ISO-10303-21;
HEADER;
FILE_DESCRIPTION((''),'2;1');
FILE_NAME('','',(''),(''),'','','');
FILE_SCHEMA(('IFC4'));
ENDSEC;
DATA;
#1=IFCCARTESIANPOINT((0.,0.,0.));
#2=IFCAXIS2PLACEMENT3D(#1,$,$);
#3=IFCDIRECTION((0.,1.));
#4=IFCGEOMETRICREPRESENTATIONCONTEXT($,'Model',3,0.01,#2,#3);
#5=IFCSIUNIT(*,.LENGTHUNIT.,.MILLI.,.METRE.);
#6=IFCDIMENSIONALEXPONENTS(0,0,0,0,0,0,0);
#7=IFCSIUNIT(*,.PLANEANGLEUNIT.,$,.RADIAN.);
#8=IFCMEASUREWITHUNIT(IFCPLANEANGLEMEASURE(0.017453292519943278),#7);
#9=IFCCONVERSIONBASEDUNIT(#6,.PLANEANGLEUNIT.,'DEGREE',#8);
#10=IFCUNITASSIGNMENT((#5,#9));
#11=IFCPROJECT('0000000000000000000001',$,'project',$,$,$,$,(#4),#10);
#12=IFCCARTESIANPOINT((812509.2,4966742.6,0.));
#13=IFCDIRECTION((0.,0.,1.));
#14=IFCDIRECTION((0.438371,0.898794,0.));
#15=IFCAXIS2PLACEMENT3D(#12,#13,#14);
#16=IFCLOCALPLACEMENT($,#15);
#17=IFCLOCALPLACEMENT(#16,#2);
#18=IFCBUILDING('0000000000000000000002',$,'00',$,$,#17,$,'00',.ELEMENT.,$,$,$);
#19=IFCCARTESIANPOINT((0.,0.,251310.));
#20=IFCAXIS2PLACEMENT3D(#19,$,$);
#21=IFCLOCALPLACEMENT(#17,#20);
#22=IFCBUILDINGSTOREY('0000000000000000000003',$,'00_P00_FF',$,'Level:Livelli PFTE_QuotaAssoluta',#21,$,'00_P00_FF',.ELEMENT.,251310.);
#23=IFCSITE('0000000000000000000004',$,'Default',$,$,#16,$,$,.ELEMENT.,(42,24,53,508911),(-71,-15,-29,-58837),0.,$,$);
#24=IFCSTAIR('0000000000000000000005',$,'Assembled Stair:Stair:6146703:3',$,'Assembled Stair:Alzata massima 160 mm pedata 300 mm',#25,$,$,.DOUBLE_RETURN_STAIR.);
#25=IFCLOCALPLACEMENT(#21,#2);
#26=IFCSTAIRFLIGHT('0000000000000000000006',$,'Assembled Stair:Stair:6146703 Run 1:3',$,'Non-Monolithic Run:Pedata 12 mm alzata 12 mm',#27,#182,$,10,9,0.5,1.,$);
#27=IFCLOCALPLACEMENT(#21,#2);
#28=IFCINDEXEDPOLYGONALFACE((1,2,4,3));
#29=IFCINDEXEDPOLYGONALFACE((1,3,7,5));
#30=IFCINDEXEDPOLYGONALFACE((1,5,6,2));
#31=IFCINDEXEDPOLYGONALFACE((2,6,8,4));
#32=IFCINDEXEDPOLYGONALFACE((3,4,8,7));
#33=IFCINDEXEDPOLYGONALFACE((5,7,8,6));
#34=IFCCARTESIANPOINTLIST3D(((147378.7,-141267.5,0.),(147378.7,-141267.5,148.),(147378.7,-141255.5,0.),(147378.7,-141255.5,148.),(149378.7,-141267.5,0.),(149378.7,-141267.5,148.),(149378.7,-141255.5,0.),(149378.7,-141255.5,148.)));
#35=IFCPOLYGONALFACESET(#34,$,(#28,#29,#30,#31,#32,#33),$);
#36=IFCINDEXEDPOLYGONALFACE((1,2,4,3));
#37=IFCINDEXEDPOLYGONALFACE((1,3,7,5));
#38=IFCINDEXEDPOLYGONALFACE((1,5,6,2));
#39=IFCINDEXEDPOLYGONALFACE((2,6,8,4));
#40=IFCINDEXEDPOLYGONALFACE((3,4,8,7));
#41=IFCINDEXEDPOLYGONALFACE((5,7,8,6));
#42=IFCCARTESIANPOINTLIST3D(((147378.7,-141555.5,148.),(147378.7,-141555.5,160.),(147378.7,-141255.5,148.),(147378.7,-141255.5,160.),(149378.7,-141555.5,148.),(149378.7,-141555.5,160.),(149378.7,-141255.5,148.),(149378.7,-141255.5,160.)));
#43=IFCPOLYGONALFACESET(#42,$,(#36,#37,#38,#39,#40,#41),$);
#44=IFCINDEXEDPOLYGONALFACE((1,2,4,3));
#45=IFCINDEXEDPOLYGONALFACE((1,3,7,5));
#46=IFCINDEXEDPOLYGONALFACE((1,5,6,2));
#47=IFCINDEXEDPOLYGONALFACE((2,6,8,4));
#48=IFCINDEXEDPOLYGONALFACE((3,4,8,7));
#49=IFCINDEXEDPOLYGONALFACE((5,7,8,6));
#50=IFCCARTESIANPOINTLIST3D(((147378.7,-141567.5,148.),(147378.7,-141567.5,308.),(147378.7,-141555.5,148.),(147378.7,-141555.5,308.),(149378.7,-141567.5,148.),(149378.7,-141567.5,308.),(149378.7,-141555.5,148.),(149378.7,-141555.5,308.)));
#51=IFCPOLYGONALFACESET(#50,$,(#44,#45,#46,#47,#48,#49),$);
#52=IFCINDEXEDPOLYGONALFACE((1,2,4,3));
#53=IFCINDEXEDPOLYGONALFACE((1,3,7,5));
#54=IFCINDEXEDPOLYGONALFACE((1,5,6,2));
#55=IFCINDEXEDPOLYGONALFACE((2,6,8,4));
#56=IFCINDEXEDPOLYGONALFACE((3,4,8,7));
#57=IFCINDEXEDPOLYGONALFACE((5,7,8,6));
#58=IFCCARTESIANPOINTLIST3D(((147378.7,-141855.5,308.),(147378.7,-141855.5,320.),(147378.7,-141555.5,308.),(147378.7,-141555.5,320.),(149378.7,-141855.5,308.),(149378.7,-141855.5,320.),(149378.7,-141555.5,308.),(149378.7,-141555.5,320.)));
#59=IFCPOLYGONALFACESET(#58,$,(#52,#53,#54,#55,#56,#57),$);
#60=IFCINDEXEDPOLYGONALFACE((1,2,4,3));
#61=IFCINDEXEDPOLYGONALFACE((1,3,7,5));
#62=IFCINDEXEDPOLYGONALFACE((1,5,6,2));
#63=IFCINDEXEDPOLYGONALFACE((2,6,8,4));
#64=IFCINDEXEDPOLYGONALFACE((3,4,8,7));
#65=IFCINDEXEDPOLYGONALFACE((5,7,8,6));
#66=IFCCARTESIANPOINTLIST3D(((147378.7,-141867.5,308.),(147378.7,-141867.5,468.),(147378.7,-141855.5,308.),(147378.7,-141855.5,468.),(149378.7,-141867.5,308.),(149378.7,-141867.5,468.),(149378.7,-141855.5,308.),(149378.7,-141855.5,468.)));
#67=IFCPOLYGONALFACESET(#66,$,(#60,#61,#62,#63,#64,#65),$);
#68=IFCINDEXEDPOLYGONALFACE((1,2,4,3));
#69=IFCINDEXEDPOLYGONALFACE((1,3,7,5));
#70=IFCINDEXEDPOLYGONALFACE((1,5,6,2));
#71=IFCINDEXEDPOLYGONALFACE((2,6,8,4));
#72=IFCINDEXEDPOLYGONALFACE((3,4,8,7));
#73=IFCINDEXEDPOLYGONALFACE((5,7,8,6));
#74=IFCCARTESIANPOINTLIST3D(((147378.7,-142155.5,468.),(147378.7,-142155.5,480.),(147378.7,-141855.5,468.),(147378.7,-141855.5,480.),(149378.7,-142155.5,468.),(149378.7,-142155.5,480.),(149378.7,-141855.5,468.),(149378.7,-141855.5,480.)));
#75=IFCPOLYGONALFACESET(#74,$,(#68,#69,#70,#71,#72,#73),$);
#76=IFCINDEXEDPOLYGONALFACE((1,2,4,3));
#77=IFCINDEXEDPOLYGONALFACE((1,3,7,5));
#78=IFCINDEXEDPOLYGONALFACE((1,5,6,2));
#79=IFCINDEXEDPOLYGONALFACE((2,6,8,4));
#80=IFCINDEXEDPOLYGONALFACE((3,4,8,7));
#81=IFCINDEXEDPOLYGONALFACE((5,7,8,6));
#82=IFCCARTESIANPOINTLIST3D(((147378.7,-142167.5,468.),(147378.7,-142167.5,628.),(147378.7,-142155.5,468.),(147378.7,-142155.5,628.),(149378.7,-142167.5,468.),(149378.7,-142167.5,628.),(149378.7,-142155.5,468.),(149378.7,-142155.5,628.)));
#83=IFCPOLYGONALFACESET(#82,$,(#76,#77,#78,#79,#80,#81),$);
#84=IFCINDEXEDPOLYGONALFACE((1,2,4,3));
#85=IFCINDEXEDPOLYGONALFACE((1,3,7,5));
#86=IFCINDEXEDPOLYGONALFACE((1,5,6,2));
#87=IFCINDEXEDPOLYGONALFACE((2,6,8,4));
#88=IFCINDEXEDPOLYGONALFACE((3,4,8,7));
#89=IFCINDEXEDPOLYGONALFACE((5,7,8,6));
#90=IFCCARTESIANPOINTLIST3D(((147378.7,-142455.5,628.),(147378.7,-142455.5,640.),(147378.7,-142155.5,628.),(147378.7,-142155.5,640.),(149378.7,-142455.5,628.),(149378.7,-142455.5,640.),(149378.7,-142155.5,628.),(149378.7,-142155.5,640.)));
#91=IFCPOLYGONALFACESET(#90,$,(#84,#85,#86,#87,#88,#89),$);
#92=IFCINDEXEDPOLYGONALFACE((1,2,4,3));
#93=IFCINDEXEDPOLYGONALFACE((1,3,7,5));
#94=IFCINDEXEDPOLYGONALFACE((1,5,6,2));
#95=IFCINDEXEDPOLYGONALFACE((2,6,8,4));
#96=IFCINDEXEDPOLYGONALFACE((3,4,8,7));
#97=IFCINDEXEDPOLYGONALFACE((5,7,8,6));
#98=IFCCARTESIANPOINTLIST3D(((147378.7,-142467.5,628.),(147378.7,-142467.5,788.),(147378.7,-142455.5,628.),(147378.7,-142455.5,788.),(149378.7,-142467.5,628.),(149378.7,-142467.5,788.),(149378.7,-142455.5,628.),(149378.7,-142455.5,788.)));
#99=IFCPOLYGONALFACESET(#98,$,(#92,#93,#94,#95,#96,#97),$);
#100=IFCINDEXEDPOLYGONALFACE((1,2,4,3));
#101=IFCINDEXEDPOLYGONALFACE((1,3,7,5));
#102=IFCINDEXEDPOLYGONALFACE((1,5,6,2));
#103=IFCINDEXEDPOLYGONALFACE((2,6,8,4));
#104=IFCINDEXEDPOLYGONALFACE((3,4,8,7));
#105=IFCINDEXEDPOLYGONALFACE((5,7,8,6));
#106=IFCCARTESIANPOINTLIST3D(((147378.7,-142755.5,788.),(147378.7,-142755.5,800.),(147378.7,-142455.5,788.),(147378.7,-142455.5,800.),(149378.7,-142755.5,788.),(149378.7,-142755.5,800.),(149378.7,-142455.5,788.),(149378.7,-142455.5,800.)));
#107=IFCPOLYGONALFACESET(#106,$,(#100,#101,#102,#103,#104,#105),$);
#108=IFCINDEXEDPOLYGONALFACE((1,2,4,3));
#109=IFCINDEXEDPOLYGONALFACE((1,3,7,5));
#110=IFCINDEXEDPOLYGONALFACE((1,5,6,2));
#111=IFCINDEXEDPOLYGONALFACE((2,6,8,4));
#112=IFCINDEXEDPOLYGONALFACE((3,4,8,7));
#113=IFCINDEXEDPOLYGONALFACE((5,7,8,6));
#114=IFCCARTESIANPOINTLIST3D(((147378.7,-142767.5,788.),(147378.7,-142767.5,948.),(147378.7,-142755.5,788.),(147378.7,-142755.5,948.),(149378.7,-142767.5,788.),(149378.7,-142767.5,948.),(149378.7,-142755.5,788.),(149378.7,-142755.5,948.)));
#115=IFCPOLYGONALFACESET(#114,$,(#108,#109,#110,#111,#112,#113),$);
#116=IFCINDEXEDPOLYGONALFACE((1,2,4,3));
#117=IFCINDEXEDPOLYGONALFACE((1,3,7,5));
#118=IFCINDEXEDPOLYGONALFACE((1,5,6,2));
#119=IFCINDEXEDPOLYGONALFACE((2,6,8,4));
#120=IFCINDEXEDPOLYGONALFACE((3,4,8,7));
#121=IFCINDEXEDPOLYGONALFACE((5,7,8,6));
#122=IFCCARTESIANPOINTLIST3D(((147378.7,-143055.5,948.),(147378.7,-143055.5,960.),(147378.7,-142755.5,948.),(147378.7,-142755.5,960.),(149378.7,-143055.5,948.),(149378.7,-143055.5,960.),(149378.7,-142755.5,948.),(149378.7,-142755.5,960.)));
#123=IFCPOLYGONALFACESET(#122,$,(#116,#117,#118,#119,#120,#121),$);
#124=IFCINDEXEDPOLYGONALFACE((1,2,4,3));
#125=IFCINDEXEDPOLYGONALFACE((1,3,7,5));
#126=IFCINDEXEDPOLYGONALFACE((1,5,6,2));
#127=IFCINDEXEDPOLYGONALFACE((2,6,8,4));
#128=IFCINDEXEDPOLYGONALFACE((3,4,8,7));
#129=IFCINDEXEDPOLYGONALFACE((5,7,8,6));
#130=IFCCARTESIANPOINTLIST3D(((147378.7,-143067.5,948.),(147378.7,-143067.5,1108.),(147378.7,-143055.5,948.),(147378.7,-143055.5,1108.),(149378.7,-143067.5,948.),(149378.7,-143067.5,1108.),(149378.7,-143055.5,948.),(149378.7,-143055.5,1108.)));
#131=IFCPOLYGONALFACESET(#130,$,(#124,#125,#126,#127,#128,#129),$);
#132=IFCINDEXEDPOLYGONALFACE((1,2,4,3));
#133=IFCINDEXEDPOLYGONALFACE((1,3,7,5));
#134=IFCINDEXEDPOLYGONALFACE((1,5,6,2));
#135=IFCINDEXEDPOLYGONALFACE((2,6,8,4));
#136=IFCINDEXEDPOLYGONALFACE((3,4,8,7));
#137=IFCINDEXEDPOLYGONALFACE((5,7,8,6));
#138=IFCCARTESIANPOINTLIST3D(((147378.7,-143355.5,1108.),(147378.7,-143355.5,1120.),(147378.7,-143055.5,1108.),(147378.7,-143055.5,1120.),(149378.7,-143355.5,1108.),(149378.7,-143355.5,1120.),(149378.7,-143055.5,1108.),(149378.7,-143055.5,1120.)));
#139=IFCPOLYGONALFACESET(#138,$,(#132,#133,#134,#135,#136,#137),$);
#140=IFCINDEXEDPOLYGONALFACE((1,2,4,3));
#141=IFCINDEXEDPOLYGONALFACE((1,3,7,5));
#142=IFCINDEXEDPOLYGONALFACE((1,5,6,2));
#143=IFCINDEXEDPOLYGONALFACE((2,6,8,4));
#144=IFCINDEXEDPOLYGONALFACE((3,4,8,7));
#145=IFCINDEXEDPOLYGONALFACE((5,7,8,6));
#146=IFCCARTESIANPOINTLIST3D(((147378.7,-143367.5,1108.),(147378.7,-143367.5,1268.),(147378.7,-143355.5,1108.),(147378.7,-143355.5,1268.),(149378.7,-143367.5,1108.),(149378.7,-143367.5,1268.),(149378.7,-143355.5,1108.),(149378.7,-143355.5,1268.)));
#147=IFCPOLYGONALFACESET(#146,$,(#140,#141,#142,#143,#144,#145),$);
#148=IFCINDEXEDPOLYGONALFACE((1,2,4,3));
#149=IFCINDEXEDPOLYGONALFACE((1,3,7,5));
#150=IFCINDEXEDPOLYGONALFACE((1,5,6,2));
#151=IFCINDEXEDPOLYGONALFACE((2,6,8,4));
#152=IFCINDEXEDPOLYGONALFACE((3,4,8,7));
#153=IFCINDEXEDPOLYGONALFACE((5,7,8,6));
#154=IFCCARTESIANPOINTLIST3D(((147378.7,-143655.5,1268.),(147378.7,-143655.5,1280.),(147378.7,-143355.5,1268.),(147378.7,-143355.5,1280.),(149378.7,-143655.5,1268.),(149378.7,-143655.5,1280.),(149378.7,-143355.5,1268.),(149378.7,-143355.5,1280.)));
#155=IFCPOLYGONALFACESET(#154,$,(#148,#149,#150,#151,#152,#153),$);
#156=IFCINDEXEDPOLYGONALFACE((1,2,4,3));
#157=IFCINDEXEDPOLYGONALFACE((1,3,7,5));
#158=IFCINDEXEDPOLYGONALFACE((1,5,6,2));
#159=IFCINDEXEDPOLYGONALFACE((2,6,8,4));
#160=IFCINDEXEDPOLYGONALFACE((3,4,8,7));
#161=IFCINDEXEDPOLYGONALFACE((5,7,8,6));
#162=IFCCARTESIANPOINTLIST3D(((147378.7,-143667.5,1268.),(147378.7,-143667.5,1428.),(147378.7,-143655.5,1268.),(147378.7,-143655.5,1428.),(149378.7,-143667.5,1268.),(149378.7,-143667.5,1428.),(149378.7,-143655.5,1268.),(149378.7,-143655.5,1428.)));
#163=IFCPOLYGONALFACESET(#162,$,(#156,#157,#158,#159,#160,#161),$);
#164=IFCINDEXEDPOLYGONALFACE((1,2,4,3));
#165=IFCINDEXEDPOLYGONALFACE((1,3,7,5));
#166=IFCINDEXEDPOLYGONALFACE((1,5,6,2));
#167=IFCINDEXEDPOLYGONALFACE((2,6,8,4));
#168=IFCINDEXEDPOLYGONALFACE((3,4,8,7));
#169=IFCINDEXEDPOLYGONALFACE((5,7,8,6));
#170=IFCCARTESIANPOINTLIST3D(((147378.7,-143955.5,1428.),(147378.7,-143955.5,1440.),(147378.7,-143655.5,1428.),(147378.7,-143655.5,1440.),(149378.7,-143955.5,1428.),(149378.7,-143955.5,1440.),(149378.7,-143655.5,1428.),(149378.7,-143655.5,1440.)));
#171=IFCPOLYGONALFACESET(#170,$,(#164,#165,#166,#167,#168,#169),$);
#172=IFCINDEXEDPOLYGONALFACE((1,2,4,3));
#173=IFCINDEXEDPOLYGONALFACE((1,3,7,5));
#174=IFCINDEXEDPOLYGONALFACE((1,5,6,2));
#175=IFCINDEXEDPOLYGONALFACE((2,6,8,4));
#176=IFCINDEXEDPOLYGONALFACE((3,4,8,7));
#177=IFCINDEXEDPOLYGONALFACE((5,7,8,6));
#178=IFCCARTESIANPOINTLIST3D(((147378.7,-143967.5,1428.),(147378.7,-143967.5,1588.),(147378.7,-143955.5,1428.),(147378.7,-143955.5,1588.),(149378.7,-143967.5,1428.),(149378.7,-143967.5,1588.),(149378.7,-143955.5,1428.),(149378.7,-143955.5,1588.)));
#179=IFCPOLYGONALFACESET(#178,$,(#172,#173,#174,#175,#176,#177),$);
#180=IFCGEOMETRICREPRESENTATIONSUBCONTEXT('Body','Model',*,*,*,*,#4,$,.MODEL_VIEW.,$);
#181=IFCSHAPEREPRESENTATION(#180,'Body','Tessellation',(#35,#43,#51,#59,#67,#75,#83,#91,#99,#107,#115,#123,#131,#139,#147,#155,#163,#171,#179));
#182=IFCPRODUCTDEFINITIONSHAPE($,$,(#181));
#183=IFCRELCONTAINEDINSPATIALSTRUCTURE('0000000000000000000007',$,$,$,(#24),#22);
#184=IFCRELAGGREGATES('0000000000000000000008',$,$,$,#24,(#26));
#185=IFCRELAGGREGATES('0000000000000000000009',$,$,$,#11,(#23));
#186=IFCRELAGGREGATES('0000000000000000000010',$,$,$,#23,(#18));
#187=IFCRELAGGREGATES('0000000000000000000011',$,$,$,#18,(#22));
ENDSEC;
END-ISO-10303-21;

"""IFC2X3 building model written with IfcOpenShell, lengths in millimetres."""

from ifc_helpers import new_model, entity, si_unit, converted_unit, direction, frame, frame_2d, origin, origin_2d_with_axis, place, context, subcontext, project, spatial, rectangle, extrude, element, aggregate, save


model = new_model("IFC2X3")

# Units and contexts
model_context = context("Model", 3, precision=0.01, world=origin(), true_north=direction((0.0, 1.0)))
body_context = subcontext(model_context, "Body", "Model", "MODEL_VIEW")
ifc_project = project(units=[si_unit("LENGTHUNIT", "METRE", prefix="MILLI"), converted_unit("PLANEANGLEUNIT", "DEGREE", entity("IfcPlaneAngleMeasure", 0.017453292519943278), si_unit("PLANEANGLEUNIT", "RADIAN"), dimensions=[0, 0, 0, 0, 0, 0, 0])], contexts=[model_context])

# Site, building, storey
site_placement = place(None, frame((812509.2, 4966742.6, 0.0), z_axis=(0.0, 0.0, 1.0), x_axis=(0.438371, 0.898794, 0.0)))
site = spatial("IfcSite", under=ifc_project, at=site_placement, Name="Default", CompositionType="ELEMENT", RefLatitude=(42, 24, 53, 508911), RefLongitude=(-71, -15, -29, -58837), RefElevation=0.0)
building_placement = place(site_placement, origin())
building = spatial("IfcBuilding", under=site, at=building_placement, Name="00", LongName="00", CompositionType="ELEMENT")
storey_placement = place(building_placement, frame((0.0, 0.0, 251310.0)))
storey = spatial("IfcBuildingStorey", under=building, at=storey_placement, Name="00_P00_FF", ObjectType="Level:Livelli PFTE_QuotaAssoluta", LongName="00_P00_FF", CompositionType="ELEMENT", Elevation=251310.0)

# Stair, stair flight
stair_1_placement = place(storey_placement, origin())
stair_1 = element("IfcStair", 1, at=stair_1_placement, inside=storey, Name="Assembled Stair:Stair:6146703:3", ObjectType="Assembled Stair:Alzata massima 160 mm pedata 300 mm", ShapeType="DOUBLE_RETURN_STAIR")
stair_flight_1_placement = place(stair_1_placement, origin())
stair_flight_1 = element("IfcStairFlight", 2, at=stair_flight_1_placement, Name="Assembled Stair:Stair:6146703 Run 1:3", ObjectType="Non-Monolithic Run:Pedata 12 mm alzata 12 mm", NumberOfRiser=10, NumberOfTreads=9, RiserHeight=0.5, TreadLength=1.0, context=body_context, shape_type="SweptSolid", body=[
    extrude(rectangle(XDim=2000.0, YDim=12.0, at=origin_2d_with_axis()), frame((148378.7, -141261.5, 0.0)), (0.0, 0.0, 1.0), 148.0),
    extrude(rectangle(XDim=300.0, YDim=2000.0, at=frame_2d((0.0, 0.0), x_axis=(1.0, 0.0))), frame((148378.7, -141405.5, 148.0), z_axis=(0.0, 0.0, 1.0), x_axis=(0.0, 1.0, 0.0)), (0.0, 0.0, 1.0), 12.0),
    extrude(rectangle(XDim=2000.0, YDim=12.0, at=origin_2d_with_axis()), frame((148378.7, -141561.5, 148.0)), (0.0, 0.0, 1.0), 160.0),
    extrude(rectangle(XDim=300.0, YDim=2000.0, at=origin_2d_with_axis()), frame((148378.7, -141705.5, 308.0), z_axis=(0.0, 0.0, 1.0), x_axis=(0.0, 1.0, 0.0)), (0.0, 0.0, 1.0), 12.0),
    extrude(rectangle(XDim=2000.0, YDim=12.0, at=origin_2d_with_axis()), frame((148378.7, -141861.5, 308.0)), (0.0, 0.0, 1.0), 160.0),
    extrude(rectangle(XDim=300.0, YDim=2000.0, at=origin_2d_with_axis()), frame((148378.7, -142005.5, 468.0), z_axis=(0.0, 0.0, 1.0), x_axis=(0.0, 1.0, 0.0)), (0.0, 0.0, 1.0), 12.0),
    extrude(rectangle(XDim=2000.0, YDim=12.0, at=origin_2d_with_axis()), frame((148378.7, -142161.5, 468.0)), (0.0, 0.0, 1.0), 160.0),
    extrude(rectangle(XDim=300.0, YDim=2000.0, at=origin_2d_with_axis()), frame((148378.7, -142305.5, 628.0), z_axis=(0.0, 0.0, 1.0), x_axis=(0.0, 1.0, 0.0)), (0.0, 0.0, 1.0), 12.0),
    extrude(rectangle(XDim=2000.0, YDim=12.0, at=origin_2d_with_axis()), frame((148378.7, -142461.5, 628.0)), (0.0, 0.0, 1.0), 160.0),
    extrude(rectangle(XDim=300.0, YDim=2000.0, at=origin_2d_with_axis()), frame((148378.7, -142605.5, 788.0), z_axis=(0.0, 0.0, 1.0), x_axis=(0.0, 1.0, 0.0)), (0.0, 0.0, 1.0), 12.0),
    extrude(rectangle(XDim=2000.0, YDim=12.0, at=origin_2d_with_axis()), frame((148378.7, -142761.5, 788.0)), (0.0, 0.0, 1.0), 160.0),
    extrude(rectangle(XDim=300.0, YDim=2000.0, at=origin_2d_with_axis()), frame((148378.7, -142905.5, 948.0), z_axis=(0.0, 0.0, 1.0), x_axis=(0.0, 1.0, 0.0)), (0.0, 0.0, 1.0), 12.0),
    extrude(rectangle(XDim=2000.0, YDim=12.0, at=origin_2d_with_axis()), frame((148378.7, -143061.5, 948.0)), (0.0, 0.0, 1.0), 160.0),
    extrude(rectangle(XDim=300.0, YDim=2000.0, at=origin_2d_with_axis()), frame((148378.7, -143205.5, 1108.0), z_axis=(0.0, 0.0, 1.0), x_axis=(0.0, 1.0, 0.0)), (0.0, 0.0, 1.0), 12.0),
    extrude(rectangle(XDim=2000.0, YDim=12.0, at=origin_2d_with_axis()), frame((148378.7, -143361.5, 1108.0)), (0.0, 0.0, 1.0), 160.0),
    extrude(rectangle(XDim=300.0, YDim=2000.0, at=origin_2d_with_axis()), frame((148378.7, -143505.5, 1268.0), z_axis=(0.0, 0.0, 1.0), x_axis=(0.0, 1.0, 0.0)), (0.0, 0.0, 1.0), 12.0),
    extrude(rectangle(XDim=2000.0, YDim=12.0, at=origin_2d_with_axis()), frame((148378.7, -143661.5, 1268.0)), (0.0, 0.0, 1.0), 160.0),
    extrude(rectangle(XDim=300.0, YDim=2000.0, at=origin_2d_with_axis()), frame((148378.7, -143805.5, 1428.0), z_axis=(0.0, 0.0, 1.0), x_axis=(0.0, 1.0, 0.0)), (0.0, 0.0, 1.0), 12.0),
    extrude(rectangle(XDim=2000.0, YDim=12.0, at=origin_2d_with_axis()), frame((148378.7, -143961.5, 1428.0)), (0.0, 0.0, 1.0), 160.0),
])
aggregate(stair_1, [stair_flight_1])

save(model, "model.ifc")
